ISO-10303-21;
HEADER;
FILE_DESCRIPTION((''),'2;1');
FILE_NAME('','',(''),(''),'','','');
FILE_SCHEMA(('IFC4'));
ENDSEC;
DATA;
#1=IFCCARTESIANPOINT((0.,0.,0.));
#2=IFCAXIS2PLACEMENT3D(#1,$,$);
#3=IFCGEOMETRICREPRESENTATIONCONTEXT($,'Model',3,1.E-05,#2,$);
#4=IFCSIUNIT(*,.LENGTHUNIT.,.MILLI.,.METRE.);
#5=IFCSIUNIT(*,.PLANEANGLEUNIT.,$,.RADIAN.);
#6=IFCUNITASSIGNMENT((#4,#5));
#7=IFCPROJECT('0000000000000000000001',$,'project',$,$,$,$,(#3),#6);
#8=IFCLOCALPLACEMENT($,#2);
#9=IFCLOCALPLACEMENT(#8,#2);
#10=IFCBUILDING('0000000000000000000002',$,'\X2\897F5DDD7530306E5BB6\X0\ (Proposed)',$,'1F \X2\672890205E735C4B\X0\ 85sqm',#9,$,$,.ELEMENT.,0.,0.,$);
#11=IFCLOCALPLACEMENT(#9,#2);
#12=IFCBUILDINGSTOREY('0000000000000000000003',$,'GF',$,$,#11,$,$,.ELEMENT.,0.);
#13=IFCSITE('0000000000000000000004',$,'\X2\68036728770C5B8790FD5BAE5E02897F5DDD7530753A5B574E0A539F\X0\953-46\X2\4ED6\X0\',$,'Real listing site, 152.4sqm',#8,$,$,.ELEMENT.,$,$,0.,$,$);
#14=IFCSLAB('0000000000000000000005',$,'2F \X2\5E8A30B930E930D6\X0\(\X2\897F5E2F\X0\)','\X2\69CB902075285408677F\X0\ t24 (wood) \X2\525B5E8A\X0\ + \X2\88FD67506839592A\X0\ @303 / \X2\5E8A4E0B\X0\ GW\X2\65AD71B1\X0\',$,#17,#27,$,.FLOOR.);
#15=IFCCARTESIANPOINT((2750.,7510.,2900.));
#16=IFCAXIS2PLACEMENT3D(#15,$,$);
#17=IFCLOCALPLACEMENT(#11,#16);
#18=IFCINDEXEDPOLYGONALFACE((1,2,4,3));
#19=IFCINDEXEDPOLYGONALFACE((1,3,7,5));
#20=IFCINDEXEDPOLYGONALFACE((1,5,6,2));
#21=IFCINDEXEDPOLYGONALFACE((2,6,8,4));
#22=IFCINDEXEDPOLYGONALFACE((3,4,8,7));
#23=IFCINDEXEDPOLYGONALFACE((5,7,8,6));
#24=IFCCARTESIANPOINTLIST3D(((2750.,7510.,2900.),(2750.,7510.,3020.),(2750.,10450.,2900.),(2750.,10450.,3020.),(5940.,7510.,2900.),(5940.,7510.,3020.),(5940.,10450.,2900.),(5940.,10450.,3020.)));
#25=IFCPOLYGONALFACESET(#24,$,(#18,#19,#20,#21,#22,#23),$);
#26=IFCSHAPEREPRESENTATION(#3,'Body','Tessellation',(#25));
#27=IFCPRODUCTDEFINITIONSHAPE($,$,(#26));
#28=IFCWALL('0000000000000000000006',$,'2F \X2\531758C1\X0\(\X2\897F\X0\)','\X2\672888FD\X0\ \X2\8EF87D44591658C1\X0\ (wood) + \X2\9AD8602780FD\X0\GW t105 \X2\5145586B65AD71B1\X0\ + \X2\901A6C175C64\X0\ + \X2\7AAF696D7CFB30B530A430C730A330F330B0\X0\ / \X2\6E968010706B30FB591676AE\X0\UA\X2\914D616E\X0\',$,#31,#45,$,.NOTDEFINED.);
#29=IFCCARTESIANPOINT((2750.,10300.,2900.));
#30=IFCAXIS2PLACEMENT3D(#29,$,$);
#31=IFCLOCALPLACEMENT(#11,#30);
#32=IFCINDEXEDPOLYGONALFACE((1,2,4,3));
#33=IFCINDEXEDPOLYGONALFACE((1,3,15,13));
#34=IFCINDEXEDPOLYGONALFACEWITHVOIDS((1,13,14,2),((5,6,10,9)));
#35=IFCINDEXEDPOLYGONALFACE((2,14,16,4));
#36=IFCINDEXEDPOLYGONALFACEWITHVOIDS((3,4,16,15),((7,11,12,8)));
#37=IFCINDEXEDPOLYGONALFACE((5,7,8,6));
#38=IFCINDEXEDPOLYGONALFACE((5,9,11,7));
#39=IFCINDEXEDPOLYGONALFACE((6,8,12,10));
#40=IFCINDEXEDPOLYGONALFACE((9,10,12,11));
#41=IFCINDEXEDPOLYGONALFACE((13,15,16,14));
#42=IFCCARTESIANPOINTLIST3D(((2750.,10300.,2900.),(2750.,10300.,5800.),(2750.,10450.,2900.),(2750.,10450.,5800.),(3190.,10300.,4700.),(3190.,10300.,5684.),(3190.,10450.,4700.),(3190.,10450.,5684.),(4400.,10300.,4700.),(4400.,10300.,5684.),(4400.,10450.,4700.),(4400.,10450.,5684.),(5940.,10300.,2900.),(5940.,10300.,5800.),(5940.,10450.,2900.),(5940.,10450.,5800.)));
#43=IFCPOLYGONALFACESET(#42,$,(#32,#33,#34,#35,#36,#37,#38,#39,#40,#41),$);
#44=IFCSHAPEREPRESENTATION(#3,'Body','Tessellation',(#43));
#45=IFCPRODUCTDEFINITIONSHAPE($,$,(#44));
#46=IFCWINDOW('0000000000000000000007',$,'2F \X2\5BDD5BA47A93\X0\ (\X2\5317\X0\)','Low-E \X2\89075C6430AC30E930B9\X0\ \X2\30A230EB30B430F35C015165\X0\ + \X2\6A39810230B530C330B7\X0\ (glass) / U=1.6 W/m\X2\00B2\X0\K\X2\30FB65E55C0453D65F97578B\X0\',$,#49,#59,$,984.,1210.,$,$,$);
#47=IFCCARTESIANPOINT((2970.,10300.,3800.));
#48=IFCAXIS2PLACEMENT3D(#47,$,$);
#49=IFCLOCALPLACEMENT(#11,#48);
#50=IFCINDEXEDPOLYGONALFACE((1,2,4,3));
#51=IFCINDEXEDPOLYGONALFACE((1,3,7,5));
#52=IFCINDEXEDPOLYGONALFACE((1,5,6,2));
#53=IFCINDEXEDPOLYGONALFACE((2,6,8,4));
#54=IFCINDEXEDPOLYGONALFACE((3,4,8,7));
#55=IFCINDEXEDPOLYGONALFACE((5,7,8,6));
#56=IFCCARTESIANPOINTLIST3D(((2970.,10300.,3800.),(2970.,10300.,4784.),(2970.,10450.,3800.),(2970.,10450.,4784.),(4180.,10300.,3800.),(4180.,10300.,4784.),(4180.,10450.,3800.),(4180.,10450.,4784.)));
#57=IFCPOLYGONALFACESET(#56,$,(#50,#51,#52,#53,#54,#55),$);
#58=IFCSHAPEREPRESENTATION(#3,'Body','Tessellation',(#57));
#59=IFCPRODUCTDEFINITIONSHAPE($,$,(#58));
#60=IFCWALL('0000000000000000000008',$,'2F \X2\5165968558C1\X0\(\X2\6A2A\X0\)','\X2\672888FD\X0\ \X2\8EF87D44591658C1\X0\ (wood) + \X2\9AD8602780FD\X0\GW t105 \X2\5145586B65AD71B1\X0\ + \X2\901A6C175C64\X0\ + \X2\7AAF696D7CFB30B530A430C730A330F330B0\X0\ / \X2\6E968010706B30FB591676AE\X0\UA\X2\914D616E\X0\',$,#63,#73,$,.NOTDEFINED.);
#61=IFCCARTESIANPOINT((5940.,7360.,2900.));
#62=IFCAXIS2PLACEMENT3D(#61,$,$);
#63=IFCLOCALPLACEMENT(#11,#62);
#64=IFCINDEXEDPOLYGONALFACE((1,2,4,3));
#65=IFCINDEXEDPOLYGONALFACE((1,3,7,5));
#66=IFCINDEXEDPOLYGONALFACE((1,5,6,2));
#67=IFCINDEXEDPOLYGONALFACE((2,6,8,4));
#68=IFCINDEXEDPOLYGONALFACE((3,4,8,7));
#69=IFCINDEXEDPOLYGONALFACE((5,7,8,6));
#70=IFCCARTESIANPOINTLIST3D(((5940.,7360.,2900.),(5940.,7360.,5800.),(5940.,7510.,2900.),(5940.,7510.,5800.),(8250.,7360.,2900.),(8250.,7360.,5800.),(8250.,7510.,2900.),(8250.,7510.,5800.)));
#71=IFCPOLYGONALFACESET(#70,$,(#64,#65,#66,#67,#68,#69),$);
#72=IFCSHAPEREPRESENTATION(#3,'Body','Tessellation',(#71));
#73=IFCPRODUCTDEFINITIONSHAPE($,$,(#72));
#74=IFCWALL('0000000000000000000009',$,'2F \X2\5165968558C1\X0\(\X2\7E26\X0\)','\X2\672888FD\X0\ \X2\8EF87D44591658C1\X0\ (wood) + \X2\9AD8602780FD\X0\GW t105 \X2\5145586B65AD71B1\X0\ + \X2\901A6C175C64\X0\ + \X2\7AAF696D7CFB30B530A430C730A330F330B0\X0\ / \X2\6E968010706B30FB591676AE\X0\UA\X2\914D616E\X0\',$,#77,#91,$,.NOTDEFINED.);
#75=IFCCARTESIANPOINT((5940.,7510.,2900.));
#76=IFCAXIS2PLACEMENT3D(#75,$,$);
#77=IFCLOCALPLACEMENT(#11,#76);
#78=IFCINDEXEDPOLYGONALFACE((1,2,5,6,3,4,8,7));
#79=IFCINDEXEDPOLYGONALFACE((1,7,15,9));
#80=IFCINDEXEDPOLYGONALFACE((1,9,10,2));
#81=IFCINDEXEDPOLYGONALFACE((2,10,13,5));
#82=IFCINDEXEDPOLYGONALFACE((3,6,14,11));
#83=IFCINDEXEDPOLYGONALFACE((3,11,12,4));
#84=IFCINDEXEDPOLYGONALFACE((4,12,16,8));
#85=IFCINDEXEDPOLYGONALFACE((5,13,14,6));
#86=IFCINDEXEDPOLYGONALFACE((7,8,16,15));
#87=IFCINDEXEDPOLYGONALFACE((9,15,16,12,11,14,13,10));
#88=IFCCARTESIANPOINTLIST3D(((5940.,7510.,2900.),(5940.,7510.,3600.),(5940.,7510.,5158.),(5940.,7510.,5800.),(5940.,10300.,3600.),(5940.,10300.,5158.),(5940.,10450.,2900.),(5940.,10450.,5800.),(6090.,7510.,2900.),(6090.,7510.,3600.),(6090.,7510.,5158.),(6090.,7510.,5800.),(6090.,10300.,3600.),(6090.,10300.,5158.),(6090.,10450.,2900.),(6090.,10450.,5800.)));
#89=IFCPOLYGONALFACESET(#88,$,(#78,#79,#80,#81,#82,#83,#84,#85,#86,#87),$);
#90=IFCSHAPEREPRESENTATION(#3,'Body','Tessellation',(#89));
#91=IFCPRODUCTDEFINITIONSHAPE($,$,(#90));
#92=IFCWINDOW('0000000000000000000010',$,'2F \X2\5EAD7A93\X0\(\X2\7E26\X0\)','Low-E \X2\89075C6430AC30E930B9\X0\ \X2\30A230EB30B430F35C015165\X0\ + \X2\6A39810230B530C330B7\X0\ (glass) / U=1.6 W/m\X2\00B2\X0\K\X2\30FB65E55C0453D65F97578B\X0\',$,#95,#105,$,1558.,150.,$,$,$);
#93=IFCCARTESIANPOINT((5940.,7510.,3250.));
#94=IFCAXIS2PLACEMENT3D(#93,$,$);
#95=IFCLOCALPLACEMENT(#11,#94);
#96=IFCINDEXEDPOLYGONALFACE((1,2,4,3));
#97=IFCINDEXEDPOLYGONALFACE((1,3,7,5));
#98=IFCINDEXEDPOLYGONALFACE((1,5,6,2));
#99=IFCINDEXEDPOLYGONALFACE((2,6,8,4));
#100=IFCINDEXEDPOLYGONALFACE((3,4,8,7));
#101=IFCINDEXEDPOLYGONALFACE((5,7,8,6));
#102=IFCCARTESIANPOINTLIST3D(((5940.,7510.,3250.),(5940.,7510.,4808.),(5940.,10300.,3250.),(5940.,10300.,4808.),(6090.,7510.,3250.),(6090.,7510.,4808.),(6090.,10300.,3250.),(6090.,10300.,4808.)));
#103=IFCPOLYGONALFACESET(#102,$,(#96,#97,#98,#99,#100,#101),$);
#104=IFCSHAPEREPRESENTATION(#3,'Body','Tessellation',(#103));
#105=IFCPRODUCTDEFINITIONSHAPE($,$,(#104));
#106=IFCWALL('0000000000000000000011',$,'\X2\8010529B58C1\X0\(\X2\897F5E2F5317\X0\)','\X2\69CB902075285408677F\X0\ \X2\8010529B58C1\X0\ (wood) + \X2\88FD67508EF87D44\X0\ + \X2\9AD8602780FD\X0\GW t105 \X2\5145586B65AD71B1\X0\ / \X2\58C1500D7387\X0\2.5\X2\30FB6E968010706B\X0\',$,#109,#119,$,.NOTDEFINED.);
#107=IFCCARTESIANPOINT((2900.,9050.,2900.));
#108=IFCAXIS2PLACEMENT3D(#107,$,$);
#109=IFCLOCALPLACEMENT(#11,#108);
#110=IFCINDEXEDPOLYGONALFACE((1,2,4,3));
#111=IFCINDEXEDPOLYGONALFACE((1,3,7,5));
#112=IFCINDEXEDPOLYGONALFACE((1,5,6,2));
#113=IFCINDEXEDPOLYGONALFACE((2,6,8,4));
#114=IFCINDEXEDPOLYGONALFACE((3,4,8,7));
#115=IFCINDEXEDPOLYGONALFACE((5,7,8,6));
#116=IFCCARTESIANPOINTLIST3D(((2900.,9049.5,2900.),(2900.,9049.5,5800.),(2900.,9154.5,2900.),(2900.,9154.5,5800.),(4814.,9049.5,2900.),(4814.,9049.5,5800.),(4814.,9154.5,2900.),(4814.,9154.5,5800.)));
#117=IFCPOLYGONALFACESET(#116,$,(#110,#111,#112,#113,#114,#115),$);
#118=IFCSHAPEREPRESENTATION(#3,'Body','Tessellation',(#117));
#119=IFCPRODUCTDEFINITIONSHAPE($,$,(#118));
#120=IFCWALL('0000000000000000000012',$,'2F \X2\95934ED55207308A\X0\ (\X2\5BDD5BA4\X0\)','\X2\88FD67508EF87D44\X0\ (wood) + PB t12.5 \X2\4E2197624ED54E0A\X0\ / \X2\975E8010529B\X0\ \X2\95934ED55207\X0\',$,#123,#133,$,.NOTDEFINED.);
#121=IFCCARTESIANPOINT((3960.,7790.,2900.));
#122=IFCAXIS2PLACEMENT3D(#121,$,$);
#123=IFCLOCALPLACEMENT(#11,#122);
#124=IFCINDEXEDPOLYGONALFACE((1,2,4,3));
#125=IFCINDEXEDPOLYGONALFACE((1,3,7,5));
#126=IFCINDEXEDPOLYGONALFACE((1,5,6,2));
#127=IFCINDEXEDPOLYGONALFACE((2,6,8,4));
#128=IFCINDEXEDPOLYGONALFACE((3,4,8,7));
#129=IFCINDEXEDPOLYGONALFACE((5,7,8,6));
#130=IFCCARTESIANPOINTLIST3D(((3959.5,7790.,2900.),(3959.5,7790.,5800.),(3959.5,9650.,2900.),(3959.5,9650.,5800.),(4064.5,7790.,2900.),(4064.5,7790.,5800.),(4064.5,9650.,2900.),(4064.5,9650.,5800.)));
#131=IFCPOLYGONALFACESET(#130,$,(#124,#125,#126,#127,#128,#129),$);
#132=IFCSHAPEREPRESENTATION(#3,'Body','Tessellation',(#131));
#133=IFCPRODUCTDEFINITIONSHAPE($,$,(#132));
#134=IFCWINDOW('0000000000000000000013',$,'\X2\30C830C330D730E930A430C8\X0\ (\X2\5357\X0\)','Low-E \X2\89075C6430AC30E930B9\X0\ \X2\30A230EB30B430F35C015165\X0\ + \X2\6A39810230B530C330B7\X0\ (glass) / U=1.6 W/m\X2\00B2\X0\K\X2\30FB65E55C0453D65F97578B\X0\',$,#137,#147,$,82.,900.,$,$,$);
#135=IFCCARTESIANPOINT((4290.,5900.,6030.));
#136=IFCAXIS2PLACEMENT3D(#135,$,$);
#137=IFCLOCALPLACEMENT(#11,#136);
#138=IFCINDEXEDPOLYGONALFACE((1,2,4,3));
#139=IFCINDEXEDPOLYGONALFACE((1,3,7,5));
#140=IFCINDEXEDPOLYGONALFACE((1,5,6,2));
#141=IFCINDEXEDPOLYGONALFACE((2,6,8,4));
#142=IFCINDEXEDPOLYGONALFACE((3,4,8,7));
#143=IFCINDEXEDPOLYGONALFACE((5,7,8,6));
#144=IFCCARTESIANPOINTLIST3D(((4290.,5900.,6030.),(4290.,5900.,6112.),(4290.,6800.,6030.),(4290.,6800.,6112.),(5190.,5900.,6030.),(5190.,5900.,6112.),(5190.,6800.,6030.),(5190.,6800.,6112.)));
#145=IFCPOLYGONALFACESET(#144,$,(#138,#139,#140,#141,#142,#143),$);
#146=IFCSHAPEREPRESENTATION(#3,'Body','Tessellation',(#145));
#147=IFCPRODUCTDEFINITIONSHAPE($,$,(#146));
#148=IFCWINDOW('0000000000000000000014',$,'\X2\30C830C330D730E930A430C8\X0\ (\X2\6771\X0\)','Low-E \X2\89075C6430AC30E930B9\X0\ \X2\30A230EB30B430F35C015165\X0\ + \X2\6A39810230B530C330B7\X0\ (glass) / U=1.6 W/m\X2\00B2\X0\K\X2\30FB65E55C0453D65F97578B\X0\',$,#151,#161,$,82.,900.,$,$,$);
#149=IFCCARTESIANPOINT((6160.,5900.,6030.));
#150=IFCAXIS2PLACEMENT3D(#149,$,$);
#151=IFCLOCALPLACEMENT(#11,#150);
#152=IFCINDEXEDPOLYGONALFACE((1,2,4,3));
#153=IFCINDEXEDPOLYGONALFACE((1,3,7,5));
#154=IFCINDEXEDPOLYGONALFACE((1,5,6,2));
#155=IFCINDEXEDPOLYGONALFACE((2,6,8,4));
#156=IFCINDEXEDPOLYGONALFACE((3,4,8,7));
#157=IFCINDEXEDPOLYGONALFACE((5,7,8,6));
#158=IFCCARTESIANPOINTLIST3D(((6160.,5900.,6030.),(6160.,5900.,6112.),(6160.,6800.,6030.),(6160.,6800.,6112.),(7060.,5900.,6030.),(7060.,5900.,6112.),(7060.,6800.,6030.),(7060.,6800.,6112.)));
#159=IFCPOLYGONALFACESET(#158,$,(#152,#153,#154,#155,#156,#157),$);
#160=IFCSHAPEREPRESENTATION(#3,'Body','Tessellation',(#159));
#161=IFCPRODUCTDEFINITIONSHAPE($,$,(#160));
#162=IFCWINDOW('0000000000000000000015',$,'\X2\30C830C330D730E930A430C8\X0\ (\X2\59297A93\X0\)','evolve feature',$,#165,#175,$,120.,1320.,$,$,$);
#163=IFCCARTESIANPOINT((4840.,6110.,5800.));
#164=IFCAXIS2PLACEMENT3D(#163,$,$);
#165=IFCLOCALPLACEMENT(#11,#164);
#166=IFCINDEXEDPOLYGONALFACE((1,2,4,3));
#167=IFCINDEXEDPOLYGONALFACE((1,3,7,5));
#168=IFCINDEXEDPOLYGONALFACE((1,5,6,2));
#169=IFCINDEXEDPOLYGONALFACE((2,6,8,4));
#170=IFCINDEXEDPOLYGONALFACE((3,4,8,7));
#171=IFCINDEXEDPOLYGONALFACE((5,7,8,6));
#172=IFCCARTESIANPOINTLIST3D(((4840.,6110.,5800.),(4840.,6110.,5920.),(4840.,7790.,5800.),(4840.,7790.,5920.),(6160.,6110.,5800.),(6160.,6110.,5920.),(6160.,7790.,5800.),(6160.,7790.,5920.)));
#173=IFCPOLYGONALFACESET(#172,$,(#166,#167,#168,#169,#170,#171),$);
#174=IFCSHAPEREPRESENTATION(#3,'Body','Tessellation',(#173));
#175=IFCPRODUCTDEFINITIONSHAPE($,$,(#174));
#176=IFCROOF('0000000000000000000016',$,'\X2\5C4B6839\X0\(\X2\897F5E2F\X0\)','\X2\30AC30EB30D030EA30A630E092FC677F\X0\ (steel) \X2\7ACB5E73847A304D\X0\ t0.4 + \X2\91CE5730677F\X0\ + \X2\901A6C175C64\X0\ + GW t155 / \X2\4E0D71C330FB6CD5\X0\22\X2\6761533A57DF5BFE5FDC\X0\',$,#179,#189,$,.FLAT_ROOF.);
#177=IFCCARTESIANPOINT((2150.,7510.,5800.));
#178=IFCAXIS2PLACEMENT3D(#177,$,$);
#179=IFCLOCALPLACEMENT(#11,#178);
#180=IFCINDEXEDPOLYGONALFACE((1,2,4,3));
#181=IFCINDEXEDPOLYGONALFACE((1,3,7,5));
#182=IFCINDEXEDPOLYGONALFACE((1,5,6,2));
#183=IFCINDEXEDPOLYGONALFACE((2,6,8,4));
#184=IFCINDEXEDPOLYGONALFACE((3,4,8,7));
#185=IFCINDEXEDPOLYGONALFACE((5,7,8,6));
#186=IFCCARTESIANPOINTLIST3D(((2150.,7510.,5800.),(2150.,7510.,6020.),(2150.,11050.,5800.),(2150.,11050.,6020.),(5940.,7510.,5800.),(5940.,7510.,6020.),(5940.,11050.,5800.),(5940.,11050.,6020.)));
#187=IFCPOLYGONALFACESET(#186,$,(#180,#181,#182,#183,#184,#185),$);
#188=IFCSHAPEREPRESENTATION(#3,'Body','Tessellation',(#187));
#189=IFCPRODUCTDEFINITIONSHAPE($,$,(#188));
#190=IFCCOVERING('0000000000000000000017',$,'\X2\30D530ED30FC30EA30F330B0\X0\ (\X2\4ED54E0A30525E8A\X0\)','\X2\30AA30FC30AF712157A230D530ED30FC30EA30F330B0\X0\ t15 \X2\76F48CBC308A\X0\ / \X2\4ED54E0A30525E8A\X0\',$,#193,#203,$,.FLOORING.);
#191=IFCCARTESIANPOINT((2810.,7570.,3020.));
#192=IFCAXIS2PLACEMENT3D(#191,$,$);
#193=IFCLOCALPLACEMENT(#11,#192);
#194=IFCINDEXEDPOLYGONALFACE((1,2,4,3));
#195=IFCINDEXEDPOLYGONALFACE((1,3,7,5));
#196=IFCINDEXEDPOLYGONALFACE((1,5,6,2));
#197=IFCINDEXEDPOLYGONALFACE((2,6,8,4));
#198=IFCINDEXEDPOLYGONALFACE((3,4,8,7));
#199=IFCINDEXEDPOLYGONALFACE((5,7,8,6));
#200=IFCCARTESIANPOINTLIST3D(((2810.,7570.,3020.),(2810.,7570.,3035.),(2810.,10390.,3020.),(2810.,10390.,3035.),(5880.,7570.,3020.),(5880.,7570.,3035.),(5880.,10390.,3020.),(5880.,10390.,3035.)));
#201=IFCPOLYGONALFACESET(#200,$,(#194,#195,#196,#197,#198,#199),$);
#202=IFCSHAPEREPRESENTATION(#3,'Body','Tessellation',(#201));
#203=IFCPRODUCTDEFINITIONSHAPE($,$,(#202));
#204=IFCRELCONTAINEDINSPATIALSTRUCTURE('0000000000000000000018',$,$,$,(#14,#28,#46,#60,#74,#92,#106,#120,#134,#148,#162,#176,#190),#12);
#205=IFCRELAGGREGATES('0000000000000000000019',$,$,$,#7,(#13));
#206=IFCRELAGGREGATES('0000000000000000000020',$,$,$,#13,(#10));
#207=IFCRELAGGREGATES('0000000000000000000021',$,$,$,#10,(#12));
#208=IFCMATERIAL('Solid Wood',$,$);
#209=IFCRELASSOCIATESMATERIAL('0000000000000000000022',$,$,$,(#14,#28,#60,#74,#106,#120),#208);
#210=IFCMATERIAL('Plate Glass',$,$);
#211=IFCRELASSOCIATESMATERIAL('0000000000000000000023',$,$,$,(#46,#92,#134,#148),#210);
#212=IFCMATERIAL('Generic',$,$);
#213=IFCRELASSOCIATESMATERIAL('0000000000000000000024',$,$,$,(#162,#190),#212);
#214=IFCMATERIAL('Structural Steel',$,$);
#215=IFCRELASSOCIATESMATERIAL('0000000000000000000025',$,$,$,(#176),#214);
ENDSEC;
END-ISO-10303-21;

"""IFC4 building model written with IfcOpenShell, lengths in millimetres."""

from ifc_helpers import new_model, si_unit, frame, frame_2d, origin, place, context, project, spatial, rectangle, extrude, material, element, fill, save


model = new_model("IFC4")

# Units and contexts
model_context = context("Model", 3, precision=1e-05, world=origin())
ifc_project = project(units=[si_unit("LENGTHUNIT", "METRE", prefix="MILLI"), si_unit("PLANEANGLEUNIT", "RADIAN")], contexts=[model_context])

# Site, building, storey
site_placement = place(None, origin())
site = spatial("IfcSite", under=ifc_project, at=site_placement, Name="栃木県宇都宮市西川田町字上原953-46他", ObjectType="Real listing site, 152.4sqm", CompositionType="ELEMENT", RefElevation=0.0)
building_placement = place(site_placement, origin())
building = spatial("IfcBuilding", under=site, at=building_placement, Name="西川田の家 (Proposed)", ObjectType="1F 木造平屋 85sqm", CompositionType="ELEMENT", ElevationOfRefHeight=0.0, ElevationOfTerrain=0.0)
storey_placement = place(building_placement, origin())
storey = spatial("IfcBuildingStorey", under=building, at=storey_placement, Name="GF", CompositionType="ELEMENT", Elevation=0.0)

# Slab
ifc_material_1 = material(Name="Solid Wood")
slab_placement = place(storey_placement, frame((2750.0, 7510.0, 2900.0)))
element("IfcSlab", 1, at=slab_placement, inside=storey, material=ifc_material_1, Name="2F 床スラブ(西帯)", Description="構造用合板 t24 (wood) 剛床 + 製材根太 @303 / 床下 GW断熱", PredefinedType="FLOOR", context=model_context, shape_type="SweptSolid", body=[
    extrude(rectangle(XDim=3190.0, YDim=2940.0, at=frame_2d((1595.0, 1470.0))), frame((2750.0, 7510.0, 2900.0)), (0.0, 0.0, 1.0), 120.0),
])

# Wall, opening, window
wall_1_placement = place(storey_placement, frame((2750.0, 10300.0, 2900.0)))
wall_1 = element("IfcWall", 2, at=wall_1_placement, inside=storey, material=ifc_material_1, Name="2F 北壁(西)", Description="木製 軸組外壁 (wood) + 高性能GW t105 充填断熱 + 通気層 + 窯業系サイディング / 準耐火・外皮UA配慮", PredefinedType="NOTDEFINED", context=model_context, shape_type="SweptSolid", body=[
    extrude(rectangle(XDim=3190.0, YDim=150.0, at=frame_2d((1595.0, 75.0))), frame((2750.0, 10300.0, 2900.0)), (0.0, 0.0, 1.0), 2900.0),
])
opening_1_placement = place(storey_placement, frame((2970.0, 10300.0, 3800.0)))
opening_1 = element("IfcOpeningElement", 3, at=opening_1_placement, cuts=wall_1, PredefinedType="NOTDEFINED", context=model_context, shape_type="SweptSolid", body=[
    extrude(rectangle(XDim=1210.0, YDim=150.0, at=frame_2d((605.0, 75.0))), frame((2970.0, 10300.0, 3800.0)), (0.0, 0.0, 1.0), 984.0),
])
ifc_material_2 = material(Name="Plate Glass")
window_1_placement = place(storey_placement, frame((2970.0, 10300.0, 3800.0)))
window_1 = element("IfcWindow", 4, at=window_1_placement, inside=storey, material=ifc_material_2, Name="2F 寝室窓 (北)", Description="Low-E 複層ガラス アルゴン封入 + 樹脂サッシ (glass) / U=1.6 W/m²K・日射取得型", OverallHeight=984.0, OverallWidth=1210.0, context=model_context, shape_type="SweptSolid", body=[
    extrude(rectangle(XDim=1210.0, YDim=150.0, at=frame_2d((605.0, 75.0))), frame((2970.0, 10300.0, 3800.0)), (0.0, 0.0, 1.0), 984.0),
])
fill(opening_1, window_1)

# Wall
wall_2_placement = place(storey_placement, frame((5940.0, 7360.0, 2900.0)))
element("IfcWall", 5, at=wall_2_placement, inside=storey, material=ifc_material_1, Name="2F 入隅壁(横)", Description="木製 軸組外壁 (wood) + 高性能GW t105 充填断熱 + 通気層 + 窯業系サイディング / 準耐火・外皮UA配慮", PredefinedType="NOTDEFINED", context=model_context, shape_type="SweptSolid", body=[
    extrude(rectangle(XDim=2310.0, YDim=150.0, at=frame_2d((1155.0, 75.0))), frame((5940.0, 7360.0, 2900.0)), (0.0, 0.0, 1.0), 2900.0),
])

# Wall, opening, window
wall_3_placement = place(storey_placement, frame((5940.0, 7510.0, 2900.0)))
wall_3 = element("IfcWall", 6, at=wall_3_placement, inside=storey, material=ifc_material_1, Name="2F 入隅壁(縦)", Description="木製 軸組外壁 (wood) + 高性能GW t105 充填断熱 + 通気層 + 窯業系サイディング / 準耐火・外皮UA配慮", PredefinedType="NOTDEFINED", context=model_context, shape_type="SweptSolid", body=[
    extrude(rectangle(XDim=150.0, YDim=2940.0, at=frame_2d((75.0, 1470.0))), frame((5940.0, 7510.0, 2900.0)), (0.0, 0.0, 1.0), 2900.0),
])
opening_2_placement = place(storey_placement, frame((5940.0, 7510.0, 3250.0)))
opening_2 = element("IfcOpeningElement", 7, at=opening_2_placement, cuts=wall_3, PredefinedType="NOTDEFINED", context=model_context, shape_type="SweptSolid", body=[
    extrude(rectangle(XDim=150.0, YDim=2790.0, at=frame_2d((75.0, 1395.0))), frame((5940.0, 7510.0, 3250.0)), (0.0, 0.0, 1.0), 1558.0),
])
window_2_placement = place(storey_placement, frame((5940.0, 7510.0, 3250.0)))
window_2 = element("IfcWindow", 8, at=window_2_placement, inside=storey, material=ifc_material_2, Name="2F 庭窓(縦)", Description="Low-E 複層ガラス アルゴン封入 + 樹脂サッシ (glass) / U=1.6 W/m²K・日射取得型", OverallHeight=1558.0, OverallWidth=150.0, context=model_context, shape_type="SweptSolid", body=[
    extrude(rectangle(XDim=150.0, YDim=2790.0, at=frame_2d((75.0, 1395.0))), frame((5940.0, 7510.0, 3250.0)), (0.0, 0.0, 1.0), 1558.0),
])
fill(opening_2, window_2)

# Walls
wall_4_placement = place(storey_placement, frame((2900.0, 9050.0, 2900.0)))
element("IfcWall", 9, at=wall_4_placement, inside=storey, material=ifc_material_1, Name="耐力壁(西帯北)", Description="構造用合板 耐力壁 (wood) + 製材軸組 + 高性能GW t105 充填断熱 / 壁倍率2.5・準耐火", PredefinedType="NOTDEFINED", context=model_context, shape_type="SweptSolid", body=[
    extrude(rectangle(XDim=1914.0, YDim=105.0, at=frame_2d((957.0, 52.0))), frame((2900.0, 9050.0, 2900.0)), (0.0, 0.0, 1.0), 2900.0),
])
wall_5_placement = place(storey_placement, frame((3960.0, 7790.0, 2900.0)))
element("IfcWall", 10, at=wall_5_placement, inside=storey, material=ifc_material_1, Name="2F 間仕切り (寝室)", Description="製材軸組 (wood) + PB t12.5 両面仕上 / 非耐力 間仕切", PredefinedType="NOTDEFINED", context=model_context, shape_type="SweptSolid", body=[
    extrude(rectangle(XDim=105.0, YDim=1860.0, at=frame_2d((52.0, 930.0))), frame((3960.0, 7790.0, 2900.0)), (0.0, 0.0, 1.0), 2900.0),
])

# Windows
window_3_placement = place(storey_placement, frame((4290.0, 5900.0, 6030.0)))
element("IfcWindow", 11, at=window_3_placement, inside=storey, material=ifc_material_2, Name="トップライト (南)", Description="Low-E 複層ガラス アルゴン封入 + 樹脂サッシ (glass) / U=1.6 W/m²K・日射取得型", OverallHeight=82.0, OverallWidth=900.0, context=model_context, shape_type="SweptSolid", body=[
    extrude(rectangle(XDim=900.0, YDim=900.0, at=frame_2d((450.0, 450.0))), frame((4290.0, 5900.0, 6030.0)), (0.0, 0.0, 1.0), 82.0),
])
window_4_placement = place(storey_placement, frame((6160.0, 5900.0, 6030.0)))
element("IfcWindow", 12, at=window_4_placement, inside=storey, material=ifc_material_2, Name="トップライト (東)", Description="Low-E 複層ガラス アルゴン封入 + 樹脂サッシ (glass) / U=1.6 W/m²K・日射取得型", OverallHeight=82.0, OverallWidth=900.0, context=model_context, shape_type="SweptSolid", body=[
    extrude(rectangle(XDim=900.0, YDim=900.0, at=frame_2d((450.0, 450.0))), frame((6160.0, 5900.0, 6030.0)), (0.0, 0.0, 1.0), 82.0),
])
ifc_material_3 = material(Name="Generic")
window_5_placement = place(storey_placement, frame((4840.0, 6110.0, 5800.0)))
element("IfcWindow", 13, at=window_5_placement, inside=storey, material=ifc_material_3, Name="トップライト (天窓)", Description="evolve feature", OverallHeight=120.0, OverallWidth=1320.0, context=model_context, shape_type="SweptSolid", body=[
    extrude(rectangle(XDim=1320.0, YDim=1680.0, at=frame_2d((660.0, 840.0))), frame((4840.0, 6110.0, 5800.0)), (0.0, 0.0, 1.0), 120.0),
])

# Roof
ifc_material_4 = material(Name="Structural Steel")
for number, where, name in (
    (14, (2150.0, 7510.0, 5800.0), "屋根(西帯)"),
):
    element("IfcRoof", number, at=place(storey_placement, frame(where)), inside=storey, material=ifc_material_4, Name=name, Description="ガルバリウム鋼板 (steel) 立平葺き t0.4 + 野地板 + 通気層 + GW t155 / 不燃・法22条区域対応", PredefinedType="FLAT_ROOF", context=model_context, shape_type="SweptSolid", body=[
        extrude(rectangle(XDim=3790.0, YDim=3540.0, at=frame_2d((1895.0, 1770.0))), frame((2150.0, 7510.0, 5800.0)), (0.0, 0.0, 1.0), 220.0),
    ])

# Covering
covering_placement = place(storey_placement, frame((2810.0, 7570.0, 3020.0)))
element("IfcCovering", 15, at=covering_placement, inside=storey, material=ifc_material_3, Name="フローリング (仕上げ床)", Description="オーク無垢フローリング t15 直貼り / 仕上げ床", PredefinedType="FLOORING", context=model_context, shape_type="SweptSolid", body=[
    extrude(rectangle(XDim=3070.0, YDim=2820.0, at=frame_2d((1535.0, 1410.0))), frame((2810.0, 7570.0, 3020.0)), (0.0, 0.0, 1.0), 15.0),
])

save(model, "model.ifc")
